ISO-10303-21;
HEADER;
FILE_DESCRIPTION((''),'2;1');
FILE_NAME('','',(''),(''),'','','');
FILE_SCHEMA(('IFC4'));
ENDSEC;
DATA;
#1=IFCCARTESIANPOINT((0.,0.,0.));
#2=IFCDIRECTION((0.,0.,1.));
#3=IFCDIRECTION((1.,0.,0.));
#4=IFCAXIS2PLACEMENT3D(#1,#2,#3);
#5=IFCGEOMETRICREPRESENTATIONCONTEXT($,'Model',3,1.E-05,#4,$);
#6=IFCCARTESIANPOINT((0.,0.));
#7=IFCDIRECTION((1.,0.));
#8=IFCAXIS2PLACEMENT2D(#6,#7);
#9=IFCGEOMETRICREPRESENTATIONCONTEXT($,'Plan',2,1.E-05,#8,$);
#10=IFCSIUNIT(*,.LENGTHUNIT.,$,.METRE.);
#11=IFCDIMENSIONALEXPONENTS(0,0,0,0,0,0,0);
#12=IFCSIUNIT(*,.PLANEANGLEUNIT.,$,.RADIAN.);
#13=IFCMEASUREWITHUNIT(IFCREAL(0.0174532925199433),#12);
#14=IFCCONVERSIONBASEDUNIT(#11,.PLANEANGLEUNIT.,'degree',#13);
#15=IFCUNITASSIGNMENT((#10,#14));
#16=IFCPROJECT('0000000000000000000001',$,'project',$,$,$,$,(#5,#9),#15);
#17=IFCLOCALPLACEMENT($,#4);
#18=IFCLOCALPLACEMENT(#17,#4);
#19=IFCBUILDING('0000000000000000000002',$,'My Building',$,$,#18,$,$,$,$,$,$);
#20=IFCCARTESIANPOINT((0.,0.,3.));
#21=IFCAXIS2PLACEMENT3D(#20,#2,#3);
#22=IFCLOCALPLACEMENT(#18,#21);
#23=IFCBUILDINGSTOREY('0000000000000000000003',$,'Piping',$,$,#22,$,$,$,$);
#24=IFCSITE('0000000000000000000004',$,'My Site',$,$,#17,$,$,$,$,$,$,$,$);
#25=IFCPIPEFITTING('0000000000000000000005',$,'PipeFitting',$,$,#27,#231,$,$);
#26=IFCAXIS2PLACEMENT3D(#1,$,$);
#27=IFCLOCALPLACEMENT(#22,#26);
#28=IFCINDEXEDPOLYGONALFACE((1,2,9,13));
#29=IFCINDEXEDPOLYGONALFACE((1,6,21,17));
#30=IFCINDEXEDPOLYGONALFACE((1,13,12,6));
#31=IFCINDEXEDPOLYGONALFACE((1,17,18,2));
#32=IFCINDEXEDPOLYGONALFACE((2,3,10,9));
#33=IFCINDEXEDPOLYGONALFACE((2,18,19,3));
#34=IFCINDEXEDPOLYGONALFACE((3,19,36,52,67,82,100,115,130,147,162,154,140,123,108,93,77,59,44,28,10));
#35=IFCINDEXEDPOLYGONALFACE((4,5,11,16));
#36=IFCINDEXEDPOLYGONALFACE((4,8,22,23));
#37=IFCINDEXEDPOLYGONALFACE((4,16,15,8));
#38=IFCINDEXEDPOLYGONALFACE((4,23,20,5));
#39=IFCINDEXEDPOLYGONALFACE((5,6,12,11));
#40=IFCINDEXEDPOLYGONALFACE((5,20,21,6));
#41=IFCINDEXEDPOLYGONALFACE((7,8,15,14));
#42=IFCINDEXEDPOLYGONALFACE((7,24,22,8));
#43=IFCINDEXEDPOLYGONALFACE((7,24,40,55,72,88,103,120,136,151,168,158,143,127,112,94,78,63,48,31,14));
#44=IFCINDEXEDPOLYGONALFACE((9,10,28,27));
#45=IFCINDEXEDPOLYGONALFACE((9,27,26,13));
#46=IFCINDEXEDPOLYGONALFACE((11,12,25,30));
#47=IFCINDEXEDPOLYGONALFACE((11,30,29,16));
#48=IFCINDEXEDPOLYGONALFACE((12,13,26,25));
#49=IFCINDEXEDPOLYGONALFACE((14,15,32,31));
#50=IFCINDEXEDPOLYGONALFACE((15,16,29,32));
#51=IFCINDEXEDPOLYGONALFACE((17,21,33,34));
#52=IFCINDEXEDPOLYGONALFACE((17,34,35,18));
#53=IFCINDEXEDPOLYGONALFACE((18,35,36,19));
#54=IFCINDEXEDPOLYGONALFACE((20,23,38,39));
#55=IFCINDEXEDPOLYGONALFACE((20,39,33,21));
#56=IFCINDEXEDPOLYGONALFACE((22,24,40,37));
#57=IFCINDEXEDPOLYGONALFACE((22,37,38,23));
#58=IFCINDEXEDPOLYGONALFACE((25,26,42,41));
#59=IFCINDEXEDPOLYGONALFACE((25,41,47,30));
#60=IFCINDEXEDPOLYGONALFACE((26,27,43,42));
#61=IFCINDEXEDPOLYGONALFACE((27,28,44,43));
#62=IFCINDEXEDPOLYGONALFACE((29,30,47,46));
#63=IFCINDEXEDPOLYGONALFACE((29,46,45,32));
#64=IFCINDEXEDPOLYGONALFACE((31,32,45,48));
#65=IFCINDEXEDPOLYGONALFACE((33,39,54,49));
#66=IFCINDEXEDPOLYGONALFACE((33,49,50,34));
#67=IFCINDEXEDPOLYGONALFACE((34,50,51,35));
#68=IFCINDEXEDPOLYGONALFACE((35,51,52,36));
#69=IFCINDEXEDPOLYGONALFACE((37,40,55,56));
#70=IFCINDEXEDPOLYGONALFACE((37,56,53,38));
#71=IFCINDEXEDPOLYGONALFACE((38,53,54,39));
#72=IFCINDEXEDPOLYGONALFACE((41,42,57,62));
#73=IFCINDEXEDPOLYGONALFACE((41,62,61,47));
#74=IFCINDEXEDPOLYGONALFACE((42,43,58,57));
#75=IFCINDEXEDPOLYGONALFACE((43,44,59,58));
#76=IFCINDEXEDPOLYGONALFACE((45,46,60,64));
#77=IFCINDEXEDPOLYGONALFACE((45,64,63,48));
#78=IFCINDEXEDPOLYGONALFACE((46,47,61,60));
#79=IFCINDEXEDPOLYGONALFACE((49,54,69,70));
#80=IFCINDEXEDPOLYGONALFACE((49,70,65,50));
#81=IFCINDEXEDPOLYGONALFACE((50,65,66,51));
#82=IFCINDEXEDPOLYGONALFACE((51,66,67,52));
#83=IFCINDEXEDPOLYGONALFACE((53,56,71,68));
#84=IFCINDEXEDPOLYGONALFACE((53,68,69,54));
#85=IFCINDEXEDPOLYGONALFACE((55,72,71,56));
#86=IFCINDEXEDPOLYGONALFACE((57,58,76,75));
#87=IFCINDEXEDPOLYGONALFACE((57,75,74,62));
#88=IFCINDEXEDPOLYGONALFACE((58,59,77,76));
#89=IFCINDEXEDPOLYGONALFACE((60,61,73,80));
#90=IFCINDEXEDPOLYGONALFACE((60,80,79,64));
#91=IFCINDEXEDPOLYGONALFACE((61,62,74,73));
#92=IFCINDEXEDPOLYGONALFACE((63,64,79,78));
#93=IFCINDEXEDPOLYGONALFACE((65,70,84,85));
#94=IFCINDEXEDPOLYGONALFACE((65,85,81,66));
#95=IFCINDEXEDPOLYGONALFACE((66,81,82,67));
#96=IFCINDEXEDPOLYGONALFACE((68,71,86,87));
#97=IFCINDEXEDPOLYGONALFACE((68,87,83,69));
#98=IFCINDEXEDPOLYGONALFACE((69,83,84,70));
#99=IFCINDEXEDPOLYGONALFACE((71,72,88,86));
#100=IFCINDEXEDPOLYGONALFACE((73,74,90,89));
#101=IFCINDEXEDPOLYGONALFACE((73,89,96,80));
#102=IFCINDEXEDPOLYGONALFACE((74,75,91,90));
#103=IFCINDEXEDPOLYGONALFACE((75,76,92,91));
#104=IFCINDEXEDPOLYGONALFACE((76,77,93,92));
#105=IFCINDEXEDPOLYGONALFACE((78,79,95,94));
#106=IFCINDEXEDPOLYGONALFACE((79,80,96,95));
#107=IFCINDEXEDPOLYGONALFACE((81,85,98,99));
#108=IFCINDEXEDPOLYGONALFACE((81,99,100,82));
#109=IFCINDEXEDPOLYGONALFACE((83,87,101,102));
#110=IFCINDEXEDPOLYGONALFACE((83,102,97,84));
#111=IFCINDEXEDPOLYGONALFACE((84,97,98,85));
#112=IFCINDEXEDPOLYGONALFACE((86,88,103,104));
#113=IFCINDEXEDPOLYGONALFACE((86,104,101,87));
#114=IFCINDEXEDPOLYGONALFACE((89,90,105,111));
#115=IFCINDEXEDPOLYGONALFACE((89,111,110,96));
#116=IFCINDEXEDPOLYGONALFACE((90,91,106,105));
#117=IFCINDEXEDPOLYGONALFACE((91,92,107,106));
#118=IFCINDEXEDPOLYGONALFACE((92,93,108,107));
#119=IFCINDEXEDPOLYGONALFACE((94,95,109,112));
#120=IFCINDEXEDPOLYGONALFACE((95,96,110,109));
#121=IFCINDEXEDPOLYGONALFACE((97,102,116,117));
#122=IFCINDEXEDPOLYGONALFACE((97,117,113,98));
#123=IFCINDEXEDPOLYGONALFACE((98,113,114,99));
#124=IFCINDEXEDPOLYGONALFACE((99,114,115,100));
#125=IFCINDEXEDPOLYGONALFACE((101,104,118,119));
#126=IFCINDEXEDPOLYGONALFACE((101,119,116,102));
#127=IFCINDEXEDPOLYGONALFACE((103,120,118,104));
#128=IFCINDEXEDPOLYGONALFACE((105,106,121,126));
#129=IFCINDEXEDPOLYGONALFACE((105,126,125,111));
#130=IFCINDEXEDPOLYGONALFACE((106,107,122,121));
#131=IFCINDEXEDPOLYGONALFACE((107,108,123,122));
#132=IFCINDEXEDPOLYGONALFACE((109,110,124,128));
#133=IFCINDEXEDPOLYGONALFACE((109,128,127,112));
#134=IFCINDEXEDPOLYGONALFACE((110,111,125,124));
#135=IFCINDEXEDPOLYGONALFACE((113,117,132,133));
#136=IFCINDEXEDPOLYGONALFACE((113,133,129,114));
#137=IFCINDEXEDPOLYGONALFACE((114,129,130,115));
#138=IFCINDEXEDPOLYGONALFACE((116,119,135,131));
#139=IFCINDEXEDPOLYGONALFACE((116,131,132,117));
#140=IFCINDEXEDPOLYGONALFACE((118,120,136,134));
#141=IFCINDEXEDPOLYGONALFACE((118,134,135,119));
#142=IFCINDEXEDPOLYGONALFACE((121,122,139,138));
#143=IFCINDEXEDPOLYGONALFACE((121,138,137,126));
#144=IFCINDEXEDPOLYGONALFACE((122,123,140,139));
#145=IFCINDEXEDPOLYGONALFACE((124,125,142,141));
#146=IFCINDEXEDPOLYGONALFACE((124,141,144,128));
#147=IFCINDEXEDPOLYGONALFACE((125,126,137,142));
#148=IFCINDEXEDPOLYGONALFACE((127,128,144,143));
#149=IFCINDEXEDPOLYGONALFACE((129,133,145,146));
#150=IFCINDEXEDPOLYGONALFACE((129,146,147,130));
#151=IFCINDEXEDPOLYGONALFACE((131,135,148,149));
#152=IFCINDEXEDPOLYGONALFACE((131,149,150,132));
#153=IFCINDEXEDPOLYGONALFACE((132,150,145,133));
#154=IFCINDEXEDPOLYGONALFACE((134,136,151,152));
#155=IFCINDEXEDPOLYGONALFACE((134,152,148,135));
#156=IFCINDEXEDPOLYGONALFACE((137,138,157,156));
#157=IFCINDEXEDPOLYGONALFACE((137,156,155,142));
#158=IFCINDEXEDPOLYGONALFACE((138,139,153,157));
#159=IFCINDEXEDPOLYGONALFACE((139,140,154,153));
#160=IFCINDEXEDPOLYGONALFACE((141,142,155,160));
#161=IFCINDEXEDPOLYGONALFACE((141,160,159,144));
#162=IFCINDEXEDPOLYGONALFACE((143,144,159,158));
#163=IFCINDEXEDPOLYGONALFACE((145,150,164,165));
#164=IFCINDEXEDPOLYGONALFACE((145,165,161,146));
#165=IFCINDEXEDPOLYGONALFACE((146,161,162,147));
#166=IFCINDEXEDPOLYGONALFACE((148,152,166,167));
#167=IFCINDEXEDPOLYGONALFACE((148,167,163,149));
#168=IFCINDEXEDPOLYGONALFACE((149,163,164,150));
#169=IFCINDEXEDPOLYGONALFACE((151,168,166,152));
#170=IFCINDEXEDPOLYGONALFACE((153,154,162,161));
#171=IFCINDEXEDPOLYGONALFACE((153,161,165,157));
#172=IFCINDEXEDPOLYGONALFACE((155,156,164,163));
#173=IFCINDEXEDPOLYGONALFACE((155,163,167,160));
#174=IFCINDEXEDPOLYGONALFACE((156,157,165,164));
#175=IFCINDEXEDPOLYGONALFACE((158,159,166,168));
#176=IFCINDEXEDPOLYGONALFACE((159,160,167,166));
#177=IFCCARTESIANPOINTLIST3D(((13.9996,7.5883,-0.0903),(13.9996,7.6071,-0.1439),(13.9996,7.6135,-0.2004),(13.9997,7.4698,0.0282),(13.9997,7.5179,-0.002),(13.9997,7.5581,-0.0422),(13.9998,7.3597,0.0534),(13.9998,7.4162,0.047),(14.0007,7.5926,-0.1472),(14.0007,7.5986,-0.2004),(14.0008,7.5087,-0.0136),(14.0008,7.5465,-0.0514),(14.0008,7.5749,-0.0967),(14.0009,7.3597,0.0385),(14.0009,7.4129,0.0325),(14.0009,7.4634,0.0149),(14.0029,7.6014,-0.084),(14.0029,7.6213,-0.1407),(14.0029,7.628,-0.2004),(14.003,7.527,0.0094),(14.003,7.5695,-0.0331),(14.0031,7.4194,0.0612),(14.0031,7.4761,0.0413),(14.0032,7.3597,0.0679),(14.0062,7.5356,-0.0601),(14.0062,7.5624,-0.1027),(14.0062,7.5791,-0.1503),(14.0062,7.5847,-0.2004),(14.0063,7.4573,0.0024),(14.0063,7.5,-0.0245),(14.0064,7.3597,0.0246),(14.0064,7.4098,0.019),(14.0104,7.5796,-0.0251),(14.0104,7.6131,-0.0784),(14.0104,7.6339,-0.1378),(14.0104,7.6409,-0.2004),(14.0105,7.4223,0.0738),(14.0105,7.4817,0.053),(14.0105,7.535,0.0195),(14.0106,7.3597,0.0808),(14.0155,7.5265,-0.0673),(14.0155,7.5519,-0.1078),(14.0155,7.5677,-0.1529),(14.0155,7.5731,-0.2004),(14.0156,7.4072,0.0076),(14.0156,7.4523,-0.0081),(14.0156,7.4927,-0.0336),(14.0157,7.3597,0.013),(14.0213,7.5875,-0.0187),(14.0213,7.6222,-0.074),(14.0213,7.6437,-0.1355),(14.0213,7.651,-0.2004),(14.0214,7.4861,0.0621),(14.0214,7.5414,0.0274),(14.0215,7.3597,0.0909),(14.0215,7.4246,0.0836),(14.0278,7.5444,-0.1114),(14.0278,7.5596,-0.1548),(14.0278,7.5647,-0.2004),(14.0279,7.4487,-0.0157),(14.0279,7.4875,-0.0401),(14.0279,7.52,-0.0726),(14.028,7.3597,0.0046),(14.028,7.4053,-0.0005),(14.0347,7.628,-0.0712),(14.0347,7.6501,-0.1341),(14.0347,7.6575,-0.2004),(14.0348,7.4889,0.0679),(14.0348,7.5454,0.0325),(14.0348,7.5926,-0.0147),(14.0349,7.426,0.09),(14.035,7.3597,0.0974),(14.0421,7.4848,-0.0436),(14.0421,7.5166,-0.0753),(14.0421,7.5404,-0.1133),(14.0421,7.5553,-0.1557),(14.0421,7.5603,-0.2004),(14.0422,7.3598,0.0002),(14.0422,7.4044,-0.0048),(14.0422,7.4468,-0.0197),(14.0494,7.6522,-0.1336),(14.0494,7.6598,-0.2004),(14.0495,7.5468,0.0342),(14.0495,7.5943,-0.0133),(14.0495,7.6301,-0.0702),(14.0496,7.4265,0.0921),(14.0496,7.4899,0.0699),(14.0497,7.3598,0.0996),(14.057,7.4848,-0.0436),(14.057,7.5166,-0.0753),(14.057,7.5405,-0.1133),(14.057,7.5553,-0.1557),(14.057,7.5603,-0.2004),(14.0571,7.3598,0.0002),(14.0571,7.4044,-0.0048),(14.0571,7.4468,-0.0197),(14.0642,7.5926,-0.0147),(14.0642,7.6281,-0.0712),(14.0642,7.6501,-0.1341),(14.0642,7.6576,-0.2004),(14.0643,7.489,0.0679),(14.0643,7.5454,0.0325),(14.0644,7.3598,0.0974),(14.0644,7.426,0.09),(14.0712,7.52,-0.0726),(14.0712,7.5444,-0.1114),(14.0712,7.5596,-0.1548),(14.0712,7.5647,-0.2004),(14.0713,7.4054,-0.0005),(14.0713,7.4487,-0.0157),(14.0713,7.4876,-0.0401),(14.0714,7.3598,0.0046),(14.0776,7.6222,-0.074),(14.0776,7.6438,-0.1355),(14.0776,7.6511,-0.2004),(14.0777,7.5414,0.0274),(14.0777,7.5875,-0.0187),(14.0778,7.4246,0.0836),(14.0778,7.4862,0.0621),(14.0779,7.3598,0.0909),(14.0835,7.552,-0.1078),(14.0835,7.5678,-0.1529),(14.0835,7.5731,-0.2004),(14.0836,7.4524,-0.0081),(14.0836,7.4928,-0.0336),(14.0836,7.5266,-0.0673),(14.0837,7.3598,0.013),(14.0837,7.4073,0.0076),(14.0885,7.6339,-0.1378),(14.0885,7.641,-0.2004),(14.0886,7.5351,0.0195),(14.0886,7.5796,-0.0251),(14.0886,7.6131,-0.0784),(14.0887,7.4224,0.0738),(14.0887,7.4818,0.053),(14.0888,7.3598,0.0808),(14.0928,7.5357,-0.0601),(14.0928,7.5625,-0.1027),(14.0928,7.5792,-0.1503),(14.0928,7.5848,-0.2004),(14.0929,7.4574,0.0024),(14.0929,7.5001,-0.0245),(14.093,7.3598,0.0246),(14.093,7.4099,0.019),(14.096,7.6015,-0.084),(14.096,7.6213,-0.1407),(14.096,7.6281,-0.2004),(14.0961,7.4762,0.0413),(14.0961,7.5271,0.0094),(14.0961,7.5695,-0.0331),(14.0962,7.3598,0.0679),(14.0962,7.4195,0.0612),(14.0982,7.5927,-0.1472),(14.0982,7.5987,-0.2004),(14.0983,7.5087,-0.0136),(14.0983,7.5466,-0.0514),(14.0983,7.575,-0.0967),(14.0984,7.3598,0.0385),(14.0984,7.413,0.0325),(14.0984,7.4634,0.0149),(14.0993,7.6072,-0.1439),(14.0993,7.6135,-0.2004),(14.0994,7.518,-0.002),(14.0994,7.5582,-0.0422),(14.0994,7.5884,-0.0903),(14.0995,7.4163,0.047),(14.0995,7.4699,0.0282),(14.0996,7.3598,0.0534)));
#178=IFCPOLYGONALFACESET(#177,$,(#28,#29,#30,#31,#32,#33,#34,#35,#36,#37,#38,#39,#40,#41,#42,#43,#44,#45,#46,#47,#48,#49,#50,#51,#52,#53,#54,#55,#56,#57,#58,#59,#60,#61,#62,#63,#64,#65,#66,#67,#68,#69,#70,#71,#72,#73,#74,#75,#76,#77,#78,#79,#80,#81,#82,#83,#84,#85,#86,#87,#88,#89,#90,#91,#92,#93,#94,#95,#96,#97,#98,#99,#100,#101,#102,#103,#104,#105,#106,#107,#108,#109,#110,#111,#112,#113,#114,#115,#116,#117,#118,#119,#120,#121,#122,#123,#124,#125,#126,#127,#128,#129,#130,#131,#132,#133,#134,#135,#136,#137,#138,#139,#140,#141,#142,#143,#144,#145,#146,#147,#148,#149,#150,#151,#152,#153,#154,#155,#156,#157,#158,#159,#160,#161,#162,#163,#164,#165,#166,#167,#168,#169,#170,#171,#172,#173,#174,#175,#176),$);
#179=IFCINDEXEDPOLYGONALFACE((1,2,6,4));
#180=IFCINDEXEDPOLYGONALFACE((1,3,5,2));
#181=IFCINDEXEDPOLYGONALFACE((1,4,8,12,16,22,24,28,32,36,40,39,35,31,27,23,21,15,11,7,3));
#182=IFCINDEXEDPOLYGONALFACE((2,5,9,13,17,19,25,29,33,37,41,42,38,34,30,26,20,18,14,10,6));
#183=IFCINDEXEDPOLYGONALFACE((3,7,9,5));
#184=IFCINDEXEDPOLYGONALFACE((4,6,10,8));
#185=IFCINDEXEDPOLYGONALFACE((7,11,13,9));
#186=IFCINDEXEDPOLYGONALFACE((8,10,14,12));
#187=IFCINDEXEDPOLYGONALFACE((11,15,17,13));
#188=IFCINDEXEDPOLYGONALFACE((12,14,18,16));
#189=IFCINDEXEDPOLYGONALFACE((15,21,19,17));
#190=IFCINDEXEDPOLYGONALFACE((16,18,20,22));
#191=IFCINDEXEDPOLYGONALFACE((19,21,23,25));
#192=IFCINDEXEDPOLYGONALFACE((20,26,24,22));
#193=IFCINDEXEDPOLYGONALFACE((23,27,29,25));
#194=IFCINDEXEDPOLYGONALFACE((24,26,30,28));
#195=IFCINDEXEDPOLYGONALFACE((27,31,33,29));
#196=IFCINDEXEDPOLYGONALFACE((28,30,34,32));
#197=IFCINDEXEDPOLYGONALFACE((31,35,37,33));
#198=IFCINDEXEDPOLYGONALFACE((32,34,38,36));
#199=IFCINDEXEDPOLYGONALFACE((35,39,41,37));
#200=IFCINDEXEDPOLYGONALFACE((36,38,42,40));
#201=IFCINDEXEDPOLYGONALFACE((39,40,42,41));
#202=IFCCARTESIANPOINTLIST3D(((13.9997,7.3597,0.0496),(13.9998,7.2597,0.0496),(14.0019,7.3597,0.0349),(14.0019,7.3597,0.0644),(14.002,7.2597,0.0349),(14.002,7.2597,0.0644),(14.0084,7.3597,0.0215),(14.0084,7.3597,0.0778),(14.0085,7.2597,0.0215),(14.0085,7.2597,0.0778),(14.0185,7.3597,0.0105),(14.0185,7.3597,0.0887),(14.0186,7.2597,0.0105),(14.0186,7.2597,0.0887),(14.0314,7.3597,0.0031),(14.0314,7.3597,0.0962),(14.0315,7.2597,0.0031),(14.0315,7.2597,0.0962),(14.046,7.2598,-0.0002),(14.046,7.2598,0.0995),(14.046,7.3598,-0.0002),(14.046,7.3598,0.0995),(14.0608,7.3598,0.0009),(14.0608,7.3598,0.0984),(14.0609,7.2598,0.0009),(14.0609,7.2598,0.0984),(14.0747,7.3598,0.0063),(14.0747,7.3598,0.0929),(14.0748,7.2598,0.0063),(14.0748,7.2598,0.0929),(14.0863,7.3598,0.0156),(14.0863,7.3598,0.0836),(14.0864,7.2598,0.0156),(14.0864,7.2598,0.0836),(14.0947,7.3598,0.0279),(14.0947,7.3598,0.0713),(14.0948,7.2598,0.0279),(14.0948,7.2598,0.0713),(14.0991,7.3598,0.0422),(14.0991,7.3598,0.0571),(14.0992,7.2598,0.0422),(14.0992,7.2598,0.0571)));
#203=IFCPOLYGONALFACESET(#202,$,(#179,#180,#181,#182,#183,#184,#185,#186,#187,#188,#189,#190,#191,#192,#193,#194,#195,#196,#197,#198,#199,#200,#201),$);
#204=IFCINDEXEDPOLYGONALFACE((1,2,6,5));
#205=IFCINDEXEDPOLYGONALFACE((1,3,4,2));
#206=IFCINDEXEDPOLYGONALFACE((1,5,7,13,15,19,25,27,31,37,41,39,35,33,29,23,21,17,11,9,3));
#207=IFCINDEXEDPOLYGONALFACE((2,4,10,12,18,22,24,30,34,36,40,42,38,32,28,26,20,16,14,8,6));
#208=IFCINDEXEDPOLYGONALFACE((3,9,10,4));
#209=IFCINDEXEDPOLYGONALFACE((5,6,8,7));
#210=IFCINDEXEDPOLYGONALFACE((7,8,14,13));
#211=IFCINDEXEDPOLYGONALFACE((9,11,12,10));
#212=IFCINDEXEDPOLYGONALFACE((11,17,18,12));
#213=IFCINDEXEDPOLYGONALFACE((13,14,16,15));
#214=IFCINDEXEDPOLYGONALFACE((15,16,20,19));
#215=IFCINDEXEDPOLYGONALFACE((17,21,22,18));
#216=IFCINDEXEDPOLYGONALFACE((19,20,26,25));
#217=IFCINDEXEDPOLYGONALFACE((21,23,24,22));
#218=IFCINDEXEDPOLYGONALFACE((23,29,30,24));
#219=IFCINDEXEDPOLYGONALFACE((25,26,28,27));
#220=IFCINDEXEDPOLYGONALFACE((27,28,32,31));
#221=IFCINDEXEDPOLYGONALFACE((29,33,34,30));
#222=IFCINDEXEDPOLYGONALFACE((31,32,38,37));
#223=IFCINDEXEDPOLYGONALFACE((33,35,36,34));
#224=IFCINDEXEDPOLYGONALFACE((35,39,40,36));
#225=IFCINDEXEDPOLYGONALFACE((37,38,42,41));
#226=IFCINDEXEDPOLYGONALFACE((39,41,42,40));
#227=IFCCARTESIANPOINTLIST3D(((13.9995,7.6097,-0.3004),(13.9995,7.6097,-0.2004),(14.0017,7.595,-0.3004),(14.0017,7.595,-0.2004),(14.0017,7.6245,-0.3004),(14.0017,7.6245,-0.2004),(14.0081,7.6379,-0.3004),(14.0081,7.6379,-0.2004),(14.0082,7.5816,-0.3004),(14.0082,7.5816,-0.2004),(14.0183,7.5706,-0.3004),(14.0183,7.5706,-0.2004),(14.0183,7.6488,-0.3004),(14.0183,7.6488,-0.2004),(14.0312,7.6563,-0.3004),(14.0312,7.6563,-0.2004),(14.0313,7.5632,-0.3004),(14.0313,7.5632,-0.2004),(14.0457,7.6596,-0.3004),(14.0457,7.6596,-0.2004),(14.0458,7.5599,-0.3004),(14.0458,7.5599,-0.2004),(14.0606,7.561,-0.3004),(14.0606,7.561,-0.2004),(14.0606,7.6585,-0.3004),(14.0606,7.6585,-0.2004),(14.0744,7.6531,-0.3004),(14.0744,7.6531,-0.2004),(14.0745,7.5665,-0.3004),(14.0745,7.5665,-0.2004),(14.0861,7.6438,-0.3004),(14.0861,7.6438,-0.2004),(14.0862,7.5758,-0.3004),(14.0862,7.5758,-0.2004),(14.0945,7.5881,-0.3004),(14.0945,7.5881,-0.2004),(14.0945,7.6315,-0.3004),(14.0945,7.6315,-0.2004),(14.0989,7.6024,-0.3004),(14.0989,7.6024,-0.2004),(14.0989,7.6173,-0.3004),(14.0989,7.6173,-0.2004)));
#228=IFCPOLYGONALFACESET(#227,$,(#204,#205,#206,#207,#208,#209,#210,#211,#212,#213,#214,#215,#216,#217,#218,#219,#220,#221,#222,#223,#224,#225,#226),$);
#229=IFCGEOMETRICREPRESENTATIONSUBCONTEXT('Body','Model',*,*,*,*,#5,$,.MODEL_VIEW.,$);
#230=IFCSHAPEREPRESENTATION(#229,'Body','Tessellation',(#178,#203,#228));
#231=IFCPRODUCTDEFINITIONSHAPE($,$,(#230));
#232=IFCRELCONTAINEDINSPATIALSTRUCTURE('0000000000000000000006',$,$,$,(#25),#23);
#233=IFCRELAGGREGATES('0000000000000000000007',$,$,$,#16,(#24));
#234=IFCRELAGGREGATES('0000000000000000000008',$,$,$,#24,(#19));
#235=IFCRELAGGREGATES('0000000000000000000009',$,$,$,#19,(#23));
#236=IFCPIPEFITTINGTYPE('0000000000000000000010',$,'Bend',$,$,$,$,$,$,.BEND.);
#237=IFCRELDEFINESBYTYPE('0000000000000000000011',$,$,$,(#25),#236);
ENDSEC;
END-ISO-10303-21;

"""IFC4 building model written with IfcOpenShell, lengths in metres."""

from ifc_helpers import new_model, entity, si_unit, converted_unit, frame, origin_with_axes, origin_2d_with_axis, place, context, subcontext, project, spatial, circle, extrude, source, transform, mapped, type_object, type_shapes, element, save


model = new_model("IFC4")

# Units and contexts
model_context = context("Model", 3, precision=1e-05, world=origin_with_axes())
plan_context = context("Plan", 2, precision=1e-05, world=origin_2d_with_axis())
body_context = subcontext(model_context, "Body", "Model", "MODEL_VIEW")
ifc_project = project(units=[si_unit("LENGTHUNIT", "METRE"), converted_unit("PLANEANGLEUNIT", "degree", entity("IfcReal", 0.0174532925199433), si_unit("PLANEANGLEUNIT", "RADIAN"), dimensions=[0, 0, 0, 0, 0, 0, 0])], contexts=[model_context, plan_context])

# Site, building, storey
site_placement = place(None, origin_with_axes())
site = spatial("IfcSite", under=ifc_project, at=site_placement, Name="My Site")
building_placement = place(site_placement, origin_with_axes())
building = spatial("IfcBuilding", under=site, at=building_placement, Name="My Building")
storey_placement = place(building_placement, frame((0.0, 0.0, 3.0), z_axis=(0.0, 0.0, 1.0), x_axis=(1.0, 0.0, 0.0)))
storey = spatial("IfcBuildingStorey", under=building, at=storey_placement, Name="Piping")

# Pipe fitting
pipe_fitting_type_1 = type_object("IfcPipeFittingType", Name="Bend", PredefinedType="BEND")
shared_shape = source(origin_with_axes(), body_context, "Body", "SolidModel", [
    entity("IfcSweptDiskSolid", entity("IfcIndexedPolyCurve", entity("IfcCartesianPointList3D", [[0.0, 0.0, 0.1], [0.0, -0.0732, 0.2768], [0.0, -0.25, 0.35]]), [entity("IfcArcIndex", [1, 2, 3])]), 0.05),
    extrude(circle(Radius=0.05), origin_with_axes(), (0.0, 0.0, 1.0), 0.1),
    extrude(circle(Radius=0.05), frame((0.0, -0.25, 0.35), z_axis=(0.0, -1.0, -0.000001), x_axis=(1.0, 0.0, 0.0)), (0.0, 0.0, 1.0), 0.1),
])
type_shapes(pipe_fitting_type_1, [shared_shape])
for number, where, z_axis, x_axis, name in (
    (1, (14.0498, 7.2598, 0.0496), (-0.000872, 1.0, 0.000001), (-1.0, -0.000872, 0.0), "PipeFitting"),
):
    element("IfcPipeFitting", number, at=place(storey_placement, frame(where, z_axis=z_axis, x_axis=x_axis)), inside=storey, type_object=pipe_fitting_type_1, Name=name, context=body_context, shape_type="MappedRepresentation", body=[
        mapped(shared_shape, transform((0.0, 0.0, 0.0), x_axis=(1.0, 0.0, 0.0), y_axis=(0.0, 1.0, 0.0), z_axis=(0.0, 0.0, 1.0), scale=1.0)),
    ])

save(model, "model.ifc")
